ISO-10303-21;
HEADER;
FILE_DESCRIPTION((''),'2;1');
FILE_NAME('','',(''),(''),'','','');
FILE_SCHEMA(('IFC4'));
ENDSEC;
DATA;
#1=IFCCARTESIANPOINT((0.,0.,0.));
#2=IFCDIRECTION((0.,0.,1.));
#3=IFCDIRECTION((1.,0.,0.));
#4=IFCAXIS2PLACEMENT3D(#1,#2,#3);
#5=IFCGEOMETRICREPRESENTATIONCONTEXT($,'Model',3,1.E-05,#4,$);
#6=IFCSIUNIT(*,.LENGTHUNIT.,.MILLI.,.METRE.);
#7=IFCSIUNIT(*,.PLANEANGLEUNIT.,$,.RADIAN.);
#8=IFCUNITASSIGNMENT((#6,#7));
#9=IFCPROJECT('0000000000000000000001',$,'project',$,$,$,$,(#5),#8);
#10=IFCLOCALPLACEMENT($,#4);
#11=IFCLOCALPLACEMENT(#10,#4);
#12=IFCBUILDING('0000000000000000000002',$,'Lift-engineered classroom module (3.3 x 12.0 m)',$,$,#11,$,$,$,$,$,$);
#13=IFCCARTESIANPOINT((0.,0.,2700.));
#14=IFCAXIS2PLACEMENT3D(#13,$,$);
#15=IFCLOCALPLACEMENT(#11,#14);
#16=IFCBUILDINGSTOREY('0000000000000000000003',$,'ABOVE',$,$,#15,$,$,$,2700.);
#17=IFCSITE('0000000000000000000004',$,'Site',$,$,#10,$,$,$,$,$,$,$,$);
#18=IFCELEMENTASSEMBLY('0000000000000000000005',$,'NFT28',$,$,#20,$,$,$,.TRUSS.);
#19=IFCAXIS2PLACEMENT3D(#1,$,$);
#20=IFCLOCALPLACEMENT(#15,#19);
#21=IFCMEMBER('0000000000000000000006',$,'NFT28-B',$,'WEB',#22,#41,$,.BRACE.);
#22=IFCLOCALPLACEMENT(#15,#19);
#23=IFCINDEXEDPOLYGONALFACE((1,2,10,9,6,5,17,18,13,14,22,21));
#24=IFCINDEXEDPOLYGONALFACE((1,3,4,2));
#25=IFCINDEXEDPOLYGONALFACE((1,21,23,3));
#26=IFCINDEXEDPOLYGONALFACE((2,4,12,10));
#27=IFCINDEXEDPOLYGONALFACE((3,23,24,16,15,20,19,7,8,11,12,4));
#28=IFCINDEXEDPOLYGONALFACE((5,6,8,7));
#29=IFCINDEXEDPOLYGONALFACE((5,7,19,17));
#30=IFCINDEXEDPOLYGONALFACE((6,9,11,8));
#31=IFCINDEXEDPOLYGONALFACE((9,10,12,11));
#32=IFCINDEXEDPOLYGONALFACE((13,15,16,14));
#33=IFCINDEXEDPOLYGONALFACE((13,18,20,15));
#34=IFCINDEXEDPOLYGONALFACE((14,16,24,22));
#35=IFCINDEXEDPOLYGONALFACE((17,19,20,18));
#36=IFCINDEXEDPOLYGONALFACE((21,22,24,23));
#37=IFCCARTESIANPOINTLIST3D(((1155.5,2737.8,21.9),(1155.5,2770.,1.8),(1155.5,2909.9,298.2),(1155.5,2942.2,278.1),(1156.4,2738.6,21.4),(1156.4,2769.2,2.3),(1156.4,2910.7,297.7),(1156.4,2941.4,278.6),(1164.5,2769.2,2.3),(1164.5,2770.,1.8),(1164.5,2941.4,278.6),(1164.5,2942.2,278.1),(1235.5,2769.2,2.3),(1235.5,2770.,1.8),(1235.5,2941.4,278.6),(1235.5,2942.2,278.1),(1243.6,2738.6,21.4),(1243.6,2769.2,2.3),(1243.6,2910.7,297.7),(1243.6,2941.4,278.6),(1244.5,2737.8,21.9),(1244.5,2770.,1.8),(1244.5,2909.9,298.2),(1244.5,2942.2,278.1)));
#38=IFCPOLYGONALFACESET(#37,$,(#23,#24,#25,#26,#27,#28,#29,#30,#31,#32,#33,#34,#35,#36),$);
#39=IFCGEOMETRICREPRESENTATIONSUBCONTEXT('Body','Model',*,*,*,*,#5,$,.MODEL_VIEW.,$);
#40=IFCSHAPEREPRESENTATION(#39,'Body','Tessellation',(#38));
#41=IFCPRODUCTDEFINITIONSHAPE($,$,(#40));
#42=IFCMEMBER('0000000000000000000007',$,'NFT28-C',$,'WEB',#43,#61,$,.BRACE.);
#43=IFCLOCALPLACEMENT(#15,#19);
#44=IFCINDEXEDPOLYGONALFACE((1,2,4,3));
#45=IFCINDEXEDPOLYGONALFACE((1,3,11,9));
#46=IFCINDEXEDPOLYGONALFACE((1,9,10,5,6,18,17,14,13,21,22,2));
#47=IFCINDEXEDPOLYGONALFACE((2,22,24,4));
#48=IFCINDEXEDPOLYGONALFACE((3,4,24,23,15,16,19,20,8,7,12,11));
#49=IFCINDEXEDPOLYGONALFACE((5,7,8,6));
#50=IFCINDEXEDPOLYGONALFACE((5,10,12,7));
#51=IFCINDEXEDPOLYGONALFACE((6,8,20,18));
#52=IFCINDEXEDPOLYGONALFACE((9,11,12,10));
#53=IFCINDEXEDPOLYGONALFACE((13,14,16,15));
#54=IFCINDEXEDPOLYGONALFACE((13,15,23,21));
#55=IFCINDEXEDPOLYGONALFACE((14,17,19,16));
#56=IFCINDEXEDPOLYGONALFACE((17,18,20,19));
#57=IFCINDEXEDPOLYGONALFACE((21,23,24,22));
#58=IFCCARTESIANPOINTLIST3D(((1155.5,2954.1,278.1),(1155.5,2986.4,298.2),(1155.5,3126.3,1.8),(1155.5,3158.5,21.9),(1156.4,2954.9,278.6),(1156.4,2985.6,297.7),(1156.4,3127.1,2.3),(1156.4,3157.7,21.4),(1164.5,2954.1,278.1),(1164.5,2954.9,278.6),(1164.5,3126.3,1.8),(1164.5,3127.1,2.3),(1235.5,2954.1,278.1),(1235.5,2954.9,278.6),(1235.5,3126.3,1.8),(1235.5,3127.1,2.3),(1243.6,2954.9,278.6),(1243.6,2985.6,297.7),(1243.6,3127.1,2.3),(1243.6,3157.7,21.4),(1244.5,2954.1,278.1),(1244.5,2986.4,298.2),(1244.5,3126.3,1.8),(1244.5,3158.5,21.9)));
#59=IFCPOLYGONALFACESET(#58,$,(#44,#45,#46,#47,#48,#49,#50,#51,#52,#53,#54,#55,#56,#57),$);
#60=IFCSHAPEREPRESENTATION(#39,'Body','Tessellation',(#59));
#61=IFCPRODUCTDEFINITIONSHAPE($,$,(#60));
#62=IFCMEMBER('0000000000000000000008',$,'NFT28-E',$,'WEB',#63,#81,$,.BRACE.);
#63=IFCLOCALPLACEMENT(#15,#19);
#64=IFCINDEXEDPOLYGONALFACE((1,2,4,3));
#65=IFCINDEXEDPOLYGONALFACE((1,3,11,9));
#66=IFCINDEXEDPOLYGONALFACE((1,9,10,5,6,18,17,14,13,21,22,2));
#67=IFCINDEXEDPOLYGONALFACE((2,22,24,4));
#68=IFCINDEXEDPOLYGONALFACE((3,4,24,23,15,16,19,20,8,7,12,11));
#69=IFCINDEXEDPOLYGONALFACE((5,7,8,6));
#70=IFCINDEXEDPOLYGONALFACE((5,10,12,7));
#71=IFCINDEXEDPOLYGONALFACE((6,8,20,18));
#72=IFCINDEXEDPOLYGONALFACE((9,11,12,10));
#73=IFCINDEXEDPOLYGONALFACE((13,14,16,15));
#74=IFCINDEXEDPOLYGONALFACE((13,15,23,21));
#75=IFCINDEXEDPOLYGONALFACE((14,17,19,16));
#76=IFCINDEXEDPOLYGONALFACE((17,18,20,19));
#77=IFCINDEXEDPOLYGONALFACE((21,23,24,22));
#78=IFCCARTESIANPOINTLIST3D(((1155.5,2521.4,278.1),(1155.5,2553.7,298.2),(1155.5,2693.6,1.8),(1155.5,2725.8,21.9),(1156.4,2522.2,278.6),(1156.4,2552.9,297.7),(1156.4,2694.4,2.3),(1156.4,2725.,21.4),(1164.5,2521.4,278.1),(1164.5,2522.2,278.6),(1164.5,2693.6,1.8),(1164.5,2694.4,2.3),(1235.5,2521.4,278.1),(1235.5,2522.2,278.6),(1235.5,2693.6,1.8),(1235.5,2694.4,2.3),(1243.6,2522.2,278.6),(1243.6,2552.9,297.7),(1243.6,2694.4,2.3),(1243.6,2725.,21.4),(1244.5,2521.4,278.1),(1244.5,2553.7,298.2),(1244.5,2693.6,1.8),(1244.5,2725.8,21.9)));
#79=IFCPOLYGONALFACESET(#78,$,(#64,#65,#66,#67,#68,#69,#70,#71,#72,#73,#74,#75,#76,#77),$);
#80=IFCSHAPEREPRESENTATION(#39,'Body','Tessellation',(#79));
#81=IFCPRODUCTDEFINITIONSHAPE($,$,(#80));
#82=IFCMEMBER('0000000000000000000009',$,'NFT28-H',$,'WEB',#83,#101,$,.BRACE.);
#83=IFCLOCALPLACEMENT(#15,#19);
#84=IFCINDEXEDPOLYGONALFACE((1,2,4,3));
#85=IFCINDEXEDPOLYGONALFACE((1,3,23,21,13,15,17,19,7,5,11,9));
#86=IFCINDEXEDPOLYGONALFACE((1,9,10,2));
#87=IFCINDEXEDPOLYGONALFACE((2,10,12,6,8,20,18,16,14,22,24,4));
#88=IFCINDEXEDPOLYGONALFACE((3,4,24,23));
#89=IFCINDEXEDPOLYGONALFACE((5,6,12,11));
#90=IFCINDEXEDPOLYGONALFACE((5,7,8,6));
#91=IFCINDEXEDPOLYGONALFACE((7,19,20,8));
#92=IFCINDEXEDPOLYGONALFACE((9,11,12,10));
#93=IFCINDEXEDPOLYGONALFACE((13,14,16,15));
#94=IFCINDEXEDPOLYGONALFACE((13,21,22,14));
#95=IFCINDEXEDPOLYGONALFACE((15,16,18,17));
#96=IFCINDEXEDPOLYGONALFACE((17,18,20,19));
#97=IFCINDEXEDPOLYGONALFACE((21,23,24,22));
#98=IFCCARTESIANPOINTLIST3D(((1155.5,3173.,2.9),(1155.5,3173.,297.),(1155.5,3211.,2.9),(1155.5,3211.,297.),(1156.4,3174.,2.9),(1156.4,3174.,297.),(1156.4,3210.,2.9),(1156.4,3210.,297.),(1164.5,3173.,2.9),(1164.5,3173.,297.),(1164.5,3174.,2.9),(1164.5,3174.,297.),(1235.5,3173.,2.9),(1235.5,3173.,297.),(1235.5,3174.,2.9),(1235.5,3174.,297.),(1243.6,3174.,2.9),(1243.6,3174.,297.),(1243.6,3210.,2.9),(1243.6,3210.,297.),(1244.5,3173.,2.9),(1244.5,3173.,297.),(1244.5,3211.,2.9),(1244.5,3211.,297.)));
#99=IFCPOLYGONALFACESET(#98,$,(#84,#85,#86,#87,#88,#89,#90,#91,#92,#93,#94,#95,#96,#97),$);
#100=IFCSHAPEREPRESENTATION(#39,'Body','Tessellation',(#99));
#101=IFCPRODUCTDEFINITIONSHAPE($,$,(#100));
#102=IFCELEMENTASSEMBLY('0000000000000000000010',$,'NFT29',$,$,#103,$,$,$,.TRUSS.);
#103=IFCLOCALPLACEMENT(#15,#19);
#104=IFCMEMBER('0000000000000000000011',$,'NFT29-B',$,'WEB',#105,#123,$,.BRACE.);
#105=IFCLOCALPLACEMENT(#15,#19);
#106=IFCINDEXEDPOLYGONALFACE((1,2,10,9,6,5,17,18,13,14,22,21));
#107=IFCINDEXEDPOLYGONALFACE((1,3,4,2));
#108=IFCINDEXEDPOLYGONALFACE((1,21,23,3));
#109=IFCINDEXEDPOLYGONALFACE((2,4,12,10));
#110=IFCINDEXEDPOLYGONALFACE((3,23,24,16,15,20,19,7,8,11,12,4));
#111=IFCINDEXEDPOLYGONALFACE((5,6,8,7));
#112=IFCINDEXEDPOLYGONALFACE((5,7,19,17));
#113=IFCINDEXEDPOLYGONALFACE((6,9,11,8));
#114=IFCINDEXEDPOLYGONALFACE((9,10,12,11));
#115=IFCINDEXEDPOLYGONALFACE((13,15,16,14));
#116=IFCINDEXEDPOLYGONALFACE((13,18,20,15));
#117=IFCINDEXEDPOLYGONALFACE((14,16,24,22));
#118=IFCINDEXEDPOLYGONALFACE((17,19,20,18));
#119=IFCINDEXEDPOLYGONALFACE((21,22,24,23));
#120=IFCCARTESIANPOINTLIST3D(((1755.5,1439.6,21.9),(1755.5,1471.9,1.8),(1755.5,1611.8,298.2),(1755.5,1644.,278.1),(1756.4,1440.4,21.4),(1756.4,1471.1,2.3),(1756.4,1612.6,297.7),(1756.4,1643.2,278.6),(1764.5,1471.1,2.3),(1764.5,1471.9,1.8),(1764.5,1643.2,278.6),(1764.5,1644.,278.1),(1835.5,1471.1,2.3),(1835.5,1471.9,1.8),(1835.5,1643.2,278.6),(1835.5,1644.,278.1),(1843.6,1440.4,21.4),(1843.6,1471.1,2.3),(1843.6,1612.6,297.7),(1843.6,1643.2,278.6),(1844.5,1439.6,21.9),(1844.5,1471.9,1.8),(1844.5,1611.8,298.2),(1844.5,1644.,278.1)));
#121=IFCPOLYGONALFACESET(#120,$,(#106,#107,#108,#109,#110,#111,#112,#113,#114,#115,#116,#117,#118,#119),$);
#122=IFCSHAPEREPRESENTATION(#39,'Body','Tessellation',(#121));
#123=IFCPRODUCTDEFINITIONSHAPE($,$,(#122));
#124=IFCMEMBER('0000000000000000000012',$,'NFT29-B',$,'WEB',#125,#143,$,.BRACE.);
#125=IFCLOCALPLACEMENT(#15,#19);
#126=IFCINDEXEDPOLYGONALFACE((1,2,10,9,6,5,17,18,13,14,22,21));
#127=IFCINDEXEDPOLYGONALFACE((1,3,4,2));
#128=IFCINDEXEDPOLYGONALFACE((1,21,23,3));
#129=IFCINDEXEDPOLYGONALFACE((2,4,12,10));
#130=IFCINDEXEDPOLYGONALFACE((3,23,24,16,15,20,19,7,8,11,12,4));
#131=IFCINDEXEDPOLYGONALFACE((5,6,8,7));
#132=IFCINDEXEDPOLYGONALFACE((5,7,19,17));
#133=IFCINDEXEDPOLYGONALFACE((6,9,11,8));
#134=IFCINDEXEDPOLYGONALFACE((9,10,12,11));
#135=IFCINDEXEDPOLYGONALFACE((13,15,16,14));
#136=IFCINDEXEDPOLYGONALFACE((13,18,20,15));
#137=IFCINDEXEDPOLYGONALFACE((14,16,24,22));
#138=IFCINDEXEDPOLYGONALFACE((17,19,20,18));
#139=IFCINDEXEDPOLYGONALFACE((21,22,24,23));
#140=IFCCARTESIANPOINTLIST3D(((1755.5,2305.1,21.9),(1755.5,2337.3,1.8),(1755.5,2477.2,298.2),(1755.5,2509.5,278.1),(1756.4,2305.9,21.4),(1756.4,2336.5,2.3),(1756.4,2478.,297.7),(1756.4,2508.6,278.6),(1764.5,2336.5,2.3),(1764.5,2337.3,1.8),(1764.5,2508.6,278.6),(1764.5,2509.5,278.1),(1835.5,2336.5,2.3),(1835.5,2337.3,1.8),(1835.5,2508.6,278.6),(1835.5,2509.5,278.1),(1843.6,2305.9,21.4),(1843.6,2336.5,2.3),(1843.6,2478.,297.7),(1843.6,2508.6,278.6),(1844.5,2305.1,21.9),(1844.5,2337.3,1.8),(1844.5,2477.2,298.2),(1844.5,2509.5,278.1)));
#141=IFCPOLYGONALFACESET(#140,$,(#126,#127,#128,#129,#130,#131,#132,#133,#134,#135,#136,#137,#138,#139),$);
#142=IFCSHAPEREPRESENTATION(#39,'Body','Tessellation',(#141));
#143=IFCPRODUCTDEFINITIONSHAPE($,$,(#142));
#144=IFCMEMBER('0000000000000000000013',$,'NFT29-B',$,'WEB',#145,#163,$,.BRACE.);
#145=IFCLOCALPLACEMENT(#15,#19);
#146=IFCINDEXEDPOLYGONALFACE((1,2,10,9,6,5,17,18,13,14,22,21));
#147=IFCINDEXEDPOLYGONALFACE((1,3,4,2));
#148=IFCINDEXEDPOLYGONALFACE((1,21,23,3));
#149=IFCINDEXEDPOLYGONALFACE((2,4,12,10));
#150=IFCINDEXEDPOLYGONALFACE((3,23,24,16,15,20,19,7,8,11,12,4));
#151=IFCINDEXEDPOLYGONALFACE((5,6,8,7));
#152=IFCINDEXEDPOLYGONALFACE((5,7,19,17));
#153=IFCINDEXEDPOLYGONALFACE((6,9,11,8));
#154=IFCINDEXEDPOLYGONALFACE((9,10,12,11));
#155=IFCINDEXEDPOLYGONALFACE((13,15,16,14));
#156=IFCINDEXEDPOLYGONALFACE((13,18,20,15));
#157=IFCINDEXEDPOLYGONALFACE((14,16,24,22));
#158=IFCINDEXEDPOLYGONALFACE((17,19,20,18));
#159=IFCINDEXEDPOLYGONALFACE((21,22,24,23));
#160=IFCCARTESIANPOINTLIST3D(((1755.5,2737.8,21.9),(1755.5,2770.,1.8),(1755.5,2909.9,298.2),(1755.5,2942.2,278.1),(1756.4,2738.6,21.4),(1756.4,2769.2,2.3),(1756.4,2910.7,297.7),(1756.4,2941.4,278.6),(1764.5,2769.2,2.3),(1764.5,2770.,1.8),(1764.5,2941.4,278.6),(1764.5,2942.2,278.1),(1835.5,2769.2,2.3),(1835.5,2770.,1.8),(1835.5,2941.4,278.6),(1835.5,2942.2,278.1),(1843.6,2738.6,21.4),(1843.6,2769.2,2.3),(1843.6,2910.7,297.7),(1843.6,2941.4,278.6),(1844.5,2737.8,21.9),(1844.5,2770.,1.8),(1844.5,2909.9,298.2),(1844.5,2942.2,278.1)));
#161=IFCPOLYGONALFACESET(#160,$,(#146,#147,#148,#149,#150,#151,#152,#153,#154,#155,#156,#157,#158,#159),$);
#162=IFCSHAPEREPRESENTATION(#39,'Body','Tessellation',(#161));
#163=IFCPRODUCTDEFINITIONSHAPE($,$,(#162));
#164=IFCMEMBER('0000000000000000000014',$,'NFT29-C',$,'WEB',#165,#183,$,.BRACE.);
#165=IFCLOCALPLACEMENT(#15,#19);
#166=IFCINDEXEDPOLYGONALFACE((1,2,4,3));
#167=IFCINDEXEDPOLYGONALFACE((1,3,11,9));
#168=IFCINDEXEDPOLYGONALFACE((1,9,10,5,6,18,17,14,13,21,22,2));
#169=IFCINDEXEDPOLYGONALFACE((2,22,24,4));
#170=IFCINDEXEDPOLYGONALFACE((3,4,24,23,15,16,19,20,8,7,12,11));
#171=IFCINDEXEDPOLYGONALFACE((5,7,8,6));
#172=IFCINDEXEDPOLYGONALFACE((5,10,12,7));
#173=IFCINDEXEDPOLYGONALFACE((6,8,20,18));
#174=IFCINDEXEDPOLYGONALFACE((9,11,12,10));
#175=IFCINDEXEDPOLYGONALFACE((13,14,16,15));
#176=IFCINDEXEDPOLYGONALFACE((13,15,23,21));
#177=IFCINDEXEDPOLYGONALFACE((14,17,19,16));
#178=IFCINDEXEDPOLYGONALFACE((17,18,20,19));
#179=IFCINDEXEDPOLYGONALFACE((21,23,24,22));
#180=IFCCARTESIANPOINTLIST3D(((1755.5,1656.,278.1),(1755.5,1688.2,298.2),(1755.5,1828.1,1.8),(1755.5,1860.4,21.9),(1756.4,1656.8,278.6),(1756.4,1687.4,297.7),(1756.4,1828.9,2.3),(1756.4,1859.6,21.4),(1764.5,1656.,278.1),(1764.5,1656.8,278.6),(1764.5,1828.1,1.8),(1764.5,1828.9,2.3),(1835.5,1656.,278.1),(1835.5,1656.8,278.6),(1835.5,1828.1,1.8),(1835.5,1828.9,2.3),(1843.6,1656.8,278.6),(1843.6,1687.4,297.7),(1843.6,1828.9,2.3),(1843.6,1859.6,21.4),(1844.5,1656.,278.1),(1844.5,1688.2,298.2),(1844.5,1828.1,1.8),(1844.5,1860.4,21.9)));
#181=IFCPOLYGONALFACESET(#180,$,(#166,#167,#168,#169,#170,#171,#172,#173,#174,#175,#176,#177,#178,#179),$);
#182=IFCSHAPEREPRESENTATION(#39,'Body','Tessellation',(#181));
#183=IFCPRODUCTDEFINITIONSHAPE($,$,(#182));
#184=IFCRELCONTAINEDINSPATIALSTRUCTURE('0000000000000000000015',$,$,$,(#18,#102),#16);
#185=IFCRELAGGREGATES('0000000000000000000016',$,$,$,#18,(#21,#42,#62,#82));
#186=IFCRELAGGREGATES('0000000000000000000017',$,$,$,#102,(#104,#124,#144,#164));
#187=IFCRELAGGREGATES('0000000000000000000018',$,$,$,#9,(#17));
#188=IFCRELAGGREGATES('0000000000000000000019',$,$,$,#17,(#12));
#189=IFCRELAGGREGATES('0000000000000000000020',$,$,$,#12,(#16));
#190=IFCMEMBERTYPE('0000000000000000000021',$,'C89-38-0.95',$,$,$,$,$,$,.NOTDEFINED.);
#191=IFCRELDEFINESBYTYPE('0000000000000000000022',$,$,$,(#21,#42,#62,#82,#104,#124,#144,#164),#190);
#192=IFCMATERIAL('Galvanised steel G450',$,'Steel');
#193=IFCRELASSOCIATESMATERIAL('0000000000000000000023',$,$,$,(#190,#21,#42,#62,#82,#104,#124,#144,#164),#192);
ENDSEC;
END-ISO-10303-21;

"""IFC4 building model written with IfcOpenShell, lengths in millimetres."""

from ifc_helpers import new_model, si_unit, frame, origin, origin_with_axes, origin_2d, place, context, subcontext, project, spatial, c_section, extrude, material, material_profile, profile_set, profile_usage, type_object, element, aggregate, save


model = new_model("IFC4")

# Units and contexts
model_context = context("Model", 3, precision=1e-05, world=origin_with_axes())
body_context = subcontext(model_context, "Body", "Model", "MODEL_VIEW")
ifc_project = project(units=[si_unit("LENGTHUNIT", "METRE", prefix="MILLI"), si_unit("PLANEANGLEUNIT", "RADIAN")], contexts=[model_context])

# Site, building, storey
site_placement = place(None, origin_with_axes())
site = spatial("IfcSite", under=ifc_project, at=site_placement, Name="Site")
building_placement = place(site_placement, origin_with_axes())
building = spatial("IfcBuilding", under=site, at=building_placement, Name="Lift-engineered classroom module (3.3 x 12.0 m)")
storey_placement = place(building_placement, frame((0.0, 0.0, 2700.0)))
storey = spatial("IfcBuildingStorey", under=building, at=storey_placement, Name="ABOVE", Elevation=2700.0)

# Element assemblies, members
assembly_1_placement = place(storey_placement, frame((1200.0, 89.0, 0.0)))
assembly_1 = element("IfcElementAssembly", 1, at=assembly_1_placement, inside=storey, Name="NFT28", PredefinedType="TRUSS")
ifc_material = material(Name="Galvanised steel G450", Category="Steel")
ifc_material_profile_1 = material_profile(ifc_material, c_section(Depth=89.0, Width=38.0, WallThickness=0.9, Girth=9.0, at=origin_2d()), Name="C89-38-0.95")
ifc_profile_set_1 = profile_set([ifc_material_profile_1], Name="C89-38-0.95")
ifc_profile_usage_1 = profile_usage(ifc_profile_set_1)
member_type_1 = type_object("IfcMemberType", Name="C89-38-0.95", PredefinedType="NOTDEFINED", material=ifc_profile_set_1)
member_1_placement = place(assembly_1_placement, frame((0.0, 2664.9, 11.8), z_axis=(0.0, 0.528797, 0.848748), x_axis=(0.0, 0.848748, -0.528797)))
member_1 = element("IfcMember", 2, at=member_1_placement, type_object=member_type_1, material=ifc_profile_usage_1, Name="NFT28-B", ObjectType="WEB", PredefinedType="BRACE", context=body_context, shape_type="SweptSolid", body=[
    extrude(c_section(Depth=89.0, Width=38.0, WallThickness=0.9, Girth=9.0, at=origin_2d()), origin(), (0.0, 0.0, 1.0), 325.6),
])
member_2_placement = place(assembly_1_placement, frame((0.0, 3053.4, 11.8), z_axis=(0.0, -0.528797, 0.848748), x_axis=(0.0, -0.848748, -0.528797)))
member_2 = element("IfcMember", 3, at=member_2_placement, type_object=member_type_1, material=ifc_profile_usage_1, Name="NFT28-C", ObjectType="WEB", PredefinedType="BRACE", context=body_context, shape_type="SweptSolid", body=[
    extrude(c_section(Depth=89.0, Width=38.0, WallThickness=0.9, Girth=9.0, at=origin_2d()), origin(), (0.0, 0.0, 1.0), 325.6),
])
member_3_placement = place(assembly_1_placement, frame((0.0, 2620.7, 11.8), z_axis=(0.0, -0.528775, 0.848762), x_axis=(0.0, -0.848762, -0.528775)))
member_3 = element("IfcMember", 4, at=member_3_placement, type_object=member_type_1, material=ifc_profile_usage_1, Name="NFT28-E", ObjectType="WEB", PredefinedType="BRACE", context=body_context, shape_type="SweptSolid", body=[
    extrude(c_section(Depth=89.0, Width=38.0, WallThickness=0.9, Girth=9.0, at=origin_2d()), origin(), (0.0, 0.0, 1.0), 325.6),
])
member_4_placement = place(assembly_1_placement, frame((0.0, 3103.0, 2.9), z_axis=(0.0, 0.0, 1.0), x_axis=(0.0, -1.0, 0.0)))
member_4 = element("IfcMember", 5, at=member_4_placement, type_object=member_type_1, material=ifc_profile_usage_1, Name="NFT28-H", ObjectType="WEB", PredefinedType="BRACE", context=body_context, shape_type="SweptSolid", body=[
    extrude(c_section(Depth=89.0, Width=38.0, WallThickness=0.9, Girth=9.0, at=origin_2d()), origin(), (0.0, 0.0, 1.0), 294.1),
])
aggregate(assembly_1, [member_1, member_2, member_3, member_4])
assembly_2_placement = place(storey_placement, frame((1800.0, 89.0, 0.0)))
assembly_2 = element("IfcElementAssembly", 6, at=assembly_2_placement, inside=storey, Name="NFT29", PredefinedType="TRUSS")
member_5_placement = place(assembly_2_placement, frame((0.0, 1366.7, 11.8), z_axis=(0.0, 0.528797, 0.848748), x_axis=(0.0, 0.848748, -0.528797)))
member_5 = element("IfcMember", 7, at=member_5_placement, type_object=member_type_1, material=ifc_profile_usage_1, Name="NFT29-B", ObjectType="WEB", PredefinedType="BRACE", context=body_context, shape_type="SweptSolid", body=[
    extrude(c_section(Depth=89.0, Width=38.0, WallThickness=0.9, Girth=9.0, at=origin_2d()), origin(), (0.0, 0.0, 1.0), 325.6),
])
member_6_placement = place(assembly_2_placement, frame((0.0, 2232.2, 11.8), z_axis=(0.0, 0.528797, 0.848748), x_axis=(0.0, 0.848748, -0.528797)))
member_6 = element("IfcMember", 8, at=member_6_placement, type_object=member_type_1, material=ifc_profile_usage_1, Name="NFT29-B", ObjectType="WEB", PredefinedType="BRACE", context=body_context, shape_type="SweptSolid", body=[
    extrude(c_section(Depth=89.0, Width=38.0, WallThickness=0.9, Girth=9.0, at=origin_2d()), origin(), (0.0, 0.0, 1.0), 325.6),
])
member_7_placement = place(assembly_2_placement, frame((0.0, 2664.9, 11.8), z_axis=(0.0, 0.528797, 0.848748), x_axis=(0.0, 0.848748, -0.528797)))
member_7 = element("IfcMember", 9, at=member_7_placement, type_object=member_type_1, material=ifc_profile_usage_1, Name="NFT29-B", ObjectType="WEB", PredefinedType="BRACE", context=body_context, shape_type="SweptSolid", body=[
    extrude(c_section(Depth=89.0, Width=38.0, WallThickness=0.9, Girth=9.0, at=origin_2d()), origin(), (0.0, 0.0, 1.0), 325.6),
])
member_8_placement = place(assembly_2_placement, frame((0.0, 1755.3, 11.8), z_axis=(0.0, -0.528797, 0.848748), x_axis=(0.0, -0.848748, -0.528797)))
member_8 = element("IfcMember", 10, at=member_8_placement, type_object=member_type_1, material=ifc_profile_usage_1, Name="NFT29-C", ObjectType="WEB", PredefinedType="BRACE", context=body_context, shape_type="SweptSolid", body=[
    extrude(c_section(Depth=89.0, Width=38.0, WallThickness=0.9, Girth=9.0, at=origin_2d()), origin(), (0.0, 0.0, 1.0), 325.6),
])
aggregate(assembly_2, [member_5, member_6, member_7, member_8])

save(model, "model.ifc")
